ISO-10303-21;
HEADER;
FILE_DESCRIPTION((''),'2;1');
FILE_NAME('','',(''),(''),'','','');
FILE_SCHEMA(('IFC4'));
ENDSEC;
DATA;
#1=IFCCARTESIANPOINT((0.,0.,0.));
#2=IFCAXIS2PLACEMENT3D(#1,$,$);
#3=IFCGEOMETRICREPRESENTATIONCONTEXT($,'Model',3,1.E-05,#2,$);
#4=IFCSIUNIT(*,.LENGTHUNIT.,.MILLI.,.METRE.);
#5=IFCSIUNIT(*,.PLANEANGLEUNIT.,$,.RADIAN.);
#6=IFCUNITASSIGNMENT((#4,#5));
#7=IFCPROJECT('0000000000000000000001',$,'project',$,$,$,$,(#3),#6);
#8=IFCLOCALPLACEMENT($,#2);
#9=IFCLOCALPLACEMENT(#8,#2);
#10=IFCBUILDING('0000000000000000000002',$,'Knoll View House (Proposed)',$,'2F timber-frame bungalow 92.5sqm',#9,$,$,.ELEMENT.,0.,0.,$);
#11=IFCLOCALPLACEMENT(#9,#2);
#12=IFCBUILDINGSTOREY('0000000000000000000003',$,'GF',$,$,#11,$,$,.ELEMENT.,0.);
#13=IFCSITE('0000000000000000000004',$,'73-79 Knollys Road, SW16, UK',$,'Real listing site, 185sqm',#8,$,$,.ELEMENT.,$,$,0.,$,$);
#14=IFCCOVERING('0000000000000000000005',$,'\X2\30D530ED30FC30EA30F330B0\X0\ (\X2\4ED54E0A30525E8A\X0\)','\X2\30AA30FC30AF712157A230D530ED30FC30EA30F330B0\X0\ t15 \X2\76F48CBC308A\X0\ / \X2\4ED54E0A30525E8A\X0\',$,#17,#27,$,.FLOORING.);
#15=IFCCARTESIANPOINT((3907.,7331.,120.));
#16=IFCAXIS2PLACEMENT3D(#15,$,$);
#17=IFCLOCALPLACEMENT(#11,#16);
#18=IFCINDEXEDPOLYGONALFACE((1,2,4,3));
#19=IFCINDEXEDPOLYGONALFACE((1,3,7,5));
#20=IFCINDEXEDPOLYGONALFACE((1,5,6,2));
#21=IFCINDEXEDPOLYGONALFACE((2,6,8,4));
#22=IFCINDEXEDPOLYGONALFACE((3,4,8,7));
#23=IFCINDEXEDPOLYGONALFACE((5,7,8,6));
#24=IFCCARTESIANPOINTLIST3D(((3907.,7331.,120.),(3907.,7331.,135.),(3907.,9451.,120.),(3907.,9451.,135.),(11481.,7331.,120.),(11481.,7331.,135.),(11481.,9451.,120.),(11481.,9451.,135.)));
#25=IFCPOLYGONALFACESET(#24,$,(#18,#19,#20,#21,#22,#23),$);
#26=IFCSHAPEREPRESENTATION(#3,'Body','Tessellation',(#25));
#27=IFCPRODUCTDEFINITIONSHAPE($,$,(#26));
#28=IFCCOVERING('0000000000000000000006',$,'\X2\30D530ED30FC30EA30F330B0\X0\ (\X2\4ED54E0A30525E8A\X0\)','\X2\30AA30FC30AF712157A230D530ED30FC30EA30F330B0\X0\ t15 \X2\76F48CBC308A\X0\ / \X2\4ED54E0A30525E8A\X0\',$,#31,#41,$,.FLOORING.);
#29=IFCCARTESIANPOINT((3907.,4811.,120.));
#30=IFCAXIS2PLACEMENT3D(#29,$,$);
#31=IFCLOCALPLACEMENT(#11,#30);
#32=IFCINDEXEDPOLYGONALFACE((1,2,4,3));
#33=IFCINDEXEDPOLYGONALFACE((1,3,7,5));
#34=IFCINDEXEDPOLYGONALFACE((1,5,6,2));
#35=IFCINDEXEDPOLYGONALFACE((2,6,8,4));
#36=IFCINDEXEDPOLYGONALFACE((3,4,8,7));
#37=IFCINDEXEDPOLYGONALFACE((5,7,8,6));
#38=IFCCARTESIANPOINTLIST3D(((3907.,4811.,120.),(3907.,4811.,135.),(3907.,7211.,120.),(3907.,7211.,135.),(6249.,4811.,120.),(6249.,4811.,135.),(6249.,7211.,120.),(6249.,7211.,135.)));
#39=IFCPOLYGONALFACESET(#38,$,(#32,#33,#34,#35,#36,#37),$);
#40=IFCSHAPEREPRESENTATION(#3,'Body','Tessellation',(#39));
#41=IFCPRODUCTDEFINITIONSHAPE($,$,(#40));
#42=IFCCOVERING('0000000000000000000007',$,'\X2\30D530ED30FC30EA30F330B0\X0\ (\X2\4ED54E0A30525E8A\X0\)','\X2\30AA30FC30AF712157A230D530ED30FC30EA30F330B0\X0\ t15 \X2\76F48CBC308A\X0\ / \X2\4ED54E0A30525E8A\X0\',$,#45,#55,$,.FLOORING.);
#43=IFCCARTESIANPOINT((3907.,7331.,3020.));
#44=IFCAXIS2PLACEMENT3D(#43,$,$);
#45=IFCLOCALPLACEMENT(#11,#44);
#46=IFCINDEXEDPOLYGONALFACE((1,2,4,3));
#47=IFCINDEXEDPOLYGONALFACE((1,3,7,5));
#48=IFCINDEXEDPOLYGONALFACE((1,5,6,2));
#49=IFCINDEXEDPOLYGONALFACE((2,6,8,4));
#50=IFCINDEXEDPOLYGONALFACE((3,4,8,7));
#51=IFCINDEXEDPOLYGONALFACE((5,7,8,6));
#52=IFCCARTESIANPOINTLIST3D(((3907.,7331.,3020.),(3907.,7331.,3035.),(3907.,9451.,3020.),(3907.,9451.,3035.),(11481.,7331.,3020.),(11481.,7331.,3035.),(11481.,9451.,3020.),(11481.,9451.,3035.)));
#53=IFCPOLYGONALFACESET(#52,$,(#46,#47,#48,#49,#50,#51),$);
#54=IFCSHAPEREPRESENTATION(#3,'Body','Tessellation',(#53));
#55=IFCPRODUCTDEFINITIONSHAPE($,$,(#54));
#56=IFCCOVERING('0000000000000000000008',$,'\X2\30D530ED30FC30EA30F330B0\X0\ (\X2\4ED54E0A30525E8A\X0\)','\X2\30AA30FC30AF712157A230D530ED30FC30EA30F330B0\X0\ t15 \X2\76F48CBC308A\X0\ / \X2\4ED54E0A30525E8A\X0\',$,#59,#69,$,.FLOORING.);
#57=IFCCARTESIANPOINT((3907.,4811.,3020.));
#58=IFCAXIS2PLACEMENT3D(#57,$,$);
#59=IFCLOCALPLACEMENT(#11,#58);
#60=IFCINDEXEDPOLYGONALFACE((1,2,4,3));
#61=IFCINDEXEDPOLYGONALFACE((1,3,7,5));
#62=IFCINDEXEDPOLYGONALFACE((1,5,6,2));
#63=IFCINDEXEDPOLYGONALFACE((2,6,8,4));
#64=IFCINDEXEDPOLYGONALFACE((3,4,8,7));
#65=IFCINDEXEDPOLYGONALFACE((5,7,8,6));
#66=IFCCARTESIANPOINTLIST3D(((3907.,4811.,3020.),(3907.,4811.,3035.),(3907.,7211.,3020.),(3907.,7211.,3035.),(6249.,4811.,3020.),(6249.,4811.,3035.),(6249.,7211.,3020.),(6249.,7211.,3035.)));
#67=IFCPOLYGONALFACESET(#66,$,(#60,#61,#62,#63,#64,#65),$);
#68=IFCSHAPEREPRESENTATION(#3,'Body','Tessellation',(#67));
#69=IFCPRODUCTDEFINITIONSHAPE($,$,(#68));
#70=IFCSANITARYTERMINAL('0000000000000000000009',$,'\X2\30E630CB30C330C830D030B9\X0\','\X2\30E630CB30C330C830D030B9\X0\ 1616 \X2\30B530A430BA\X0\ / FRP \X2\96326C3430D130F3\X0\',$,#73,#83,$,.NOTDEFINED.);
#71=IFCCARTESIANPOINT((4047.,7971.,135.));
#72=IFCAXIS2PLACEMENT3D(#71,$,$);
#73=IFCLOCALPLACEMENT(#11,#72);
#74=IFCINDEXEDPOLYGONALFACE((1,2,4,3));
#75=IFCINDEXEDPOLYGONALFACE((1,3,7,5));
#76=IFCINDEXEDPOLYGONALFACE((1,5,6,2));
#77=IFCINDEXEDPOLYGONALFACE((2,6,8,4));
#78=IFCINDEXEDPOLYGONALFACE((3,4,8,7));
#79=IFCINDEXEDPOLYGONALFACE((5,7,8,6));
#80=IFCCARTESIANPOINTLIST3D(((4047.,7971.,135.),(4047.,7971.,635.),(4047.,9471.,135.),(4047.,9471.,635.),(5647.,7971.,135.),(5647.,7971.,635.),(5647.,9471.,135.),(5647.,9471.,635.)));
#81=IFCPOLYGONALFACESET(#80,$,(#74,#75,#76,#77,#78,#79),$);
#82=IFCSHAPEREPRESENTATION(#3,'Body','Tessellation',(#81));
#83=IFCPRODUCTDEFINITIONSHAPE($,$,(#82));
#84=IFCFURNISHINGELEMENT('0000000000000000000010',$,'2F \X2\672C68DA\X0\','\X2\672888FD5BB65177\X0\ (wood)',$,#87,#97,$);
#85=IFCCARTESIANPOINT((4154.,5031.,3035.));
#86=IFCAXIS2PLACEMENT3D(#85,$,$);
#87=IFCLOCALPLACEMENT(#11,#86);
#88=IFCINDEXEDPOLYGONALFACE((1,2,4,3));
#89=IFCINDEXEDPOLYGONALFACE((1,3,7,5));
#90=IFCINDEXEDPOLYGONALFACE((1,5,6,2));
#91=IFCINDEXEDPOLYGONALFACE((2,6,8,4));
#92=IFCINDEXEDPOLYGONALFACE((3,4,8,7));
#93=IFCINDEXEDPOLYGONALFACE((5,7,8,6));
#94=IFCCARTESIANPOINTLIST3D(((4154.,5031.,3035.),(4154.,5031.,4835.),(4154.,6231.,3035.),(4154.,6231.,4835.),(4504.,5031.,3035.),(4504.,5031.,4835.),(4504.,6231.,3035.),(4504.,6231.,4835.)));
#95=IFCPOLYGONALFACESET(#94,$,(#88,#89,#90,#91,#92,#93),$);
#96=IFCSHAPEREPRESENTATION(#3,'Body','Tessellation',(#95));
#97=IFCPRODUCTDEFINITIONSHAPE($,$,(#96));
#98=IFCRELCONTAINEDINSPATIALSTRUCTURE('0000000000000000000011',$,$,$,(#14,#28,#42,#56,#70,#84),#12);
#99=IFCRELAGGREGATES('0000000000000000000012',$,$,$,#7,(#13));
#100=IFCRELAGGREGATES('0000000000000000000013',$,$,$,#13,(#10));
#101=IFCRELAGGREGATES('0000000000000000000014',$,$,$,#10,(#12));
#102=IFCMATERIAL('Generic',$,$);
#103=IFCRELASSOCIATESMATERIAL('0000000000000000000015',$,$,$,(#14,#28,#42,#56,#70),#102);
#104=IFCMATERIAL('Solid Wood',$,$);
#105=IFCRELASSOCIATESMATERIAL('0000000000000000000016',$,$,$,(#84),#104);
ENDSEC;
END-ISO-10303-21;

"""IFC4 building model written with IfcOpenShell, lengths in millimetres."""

from ifc_helpers import new_model, si_unit, frame, frame_2d, origin, place, context, project, spatial, rectangle, extrude, material, element, save


model = new_model("IFC4")

# Units and contexts
model_context = context("Model", 3, precision=1e-05, world=origin())
ifc_project = project(units=[si_unit("LENGTHUNIT", "METRE", prefix="MILLI"), si_unit("PLANEANGLEUNIT", "RADIAN")], contexts=[model_context])

# Site, building, storey
site_placement = place(None, origin())
site = spatial("IfcSite", under=ifc_project, at=site_placement, Name="73-79 Knollys Road, SW16, UK", ObjectType="Real listing site, 185sqm", CompositionType="ELEMENT", RefElevation=0.0)
building_placement = place(site_placement, origin())
building = spatial("IfcBuilding", under=site, at=building_placement, Name="Knoll View House (Proposed)", ObjectType="2F timber-frame bungalow 92.5sqm", CompositionType="ELEMENT", ElevationOfRefHeight=0.0, ElevationOfTerrain=0.0)
storey_placement = place(building_placement, origin())
storey = spatial("IfcBuildingStorey", under=building, at=storey_placement, Name="GF", CompositionType="ELEMENT", Elevation=0.0)

# Shared definitions
ifc_material_1 = material(Name="Solid Wood")

# Coverings
ifc_material_2 = material(Name="Generic")
covering_1_placement = place(storey_placement, frame((3907.0, 7331.0, 120.0)))
element("IfcCovering", 1, at=covering_1_placement, inside=storey, material=ifc_material_2, Name="フローリング (仕上げ床)", Description="オーク無垢フローリング t15 直貼り / 仕上げ床", PredefinedType="FLOORING", context=model_context, shape_type="SweptSolid", body=[
    extrude(rectangle(XDim=7574.0, YDim=2120.0, at=frame_2d((3787.0, 1060.0))), frame((3907.0, 7331.0, 120.0)), (0.0, 0.0, 1.0), 15.0),
])
covering_2_placement = place(storey_placement, frame((3907.0, 4811.0, 120.0)))
element("IfcCovering", 2, at=covering_2_placement, inside=storey, material=ifc_material_2, Name="フローリング (仕上げ床)", Description="オーク無垢フローリング t15 直貼り / 仕上げ床", PredefinedType="FLOORING", context=model_context, shape_type="SweptSolid", body=[
    extrude(rectangle(XDim=2342.0, YDim=2400.0, at=frame_2d((1171.0, 1200.0))), frame((3907.0, 4811.0, 120.0)), (0.0, 0.0, 1.0), 15.0),
])
covering_3_placement = place(storey_placement, frame((3907.0, 7331.0, 3020.0)))
element("IfcCovering", 3, at=covering_3_placement, inside=storey, material=ifc_material_2, Name="フローリング (仕上げ床)", Description="オーク無垢フローリング t15 直貼り / 仕上げ床", PredefinedType="FLOORING", context=model_context, shape_type="SweptSolid", body=[
    extrude(rectangle(XDim=7574.0, YDim=2120.0, at=frame_2d((3787.0, 1060.0))), frame((3907.0, 7331.0, 3020.0)), (0.0, 0.0, 1.0), 15.0),
])
covering_4_placement = place(storey_placement, frame((3907.0, 4811.0, 3020.0)))
element("IfcCovering", 4, at=covering_4_placement, inside=storey, material=ifc_material_2, Name="フローリング (仕上げ床)", Description="オーク無垢フローリング t15 直貼り / 仕上げ床", PredefinedType="FLOORING", context=model_context, shape_type="SweptSolid", body=[
    extrude(rectangle(XDim=2342.0, YDim=2400.0, at=frame_2d((1171.0, 1200.0))), frame((3907.0, 4811.0, 3020.0)), (0.0, 0.0, 1.0), 15.0),
])

# Sanitary terminal
sanitary_terminal_placement = place(storey_placement, frame((4047.0, 7971.0, 135.0)))
element("IfcSanitaryTerminal", 5, at=sanitary_terminal_placement, inside=storey, material=ifc_material_2, Name="ユニットバス", Description="ユニットバス 1616 サイズ / FRP 防水パン", PredefinedType="NOTDEFINED", context=model_context, shape_type="SweptSolid", body=[
    extrude(rectangle(XDim=1600.0, YDim=1500.0, at=frame_2d((800.0, 750.0))), frame((4047.0, 7971.0, 135.0)), (0.0, 0.0, 1.0), 500.0),
])

# Furnishing element
furnishing_placement = place(storey_placement, frame((4154.0, 5031.0, 3035.0)))
element("IfcFurnishingElement", 6, at=furnishing_placement, inside=storey, material=ifc_material_1, Name="2F 本棚", Description="木製家具 (wood)", context=model_context, shape_type="SweptSolid", body=[
    extrude(rectangle(XDim=350.0, YDim=1200.0, at=frame_2d((175.0, 600.0))), frame((4154.0, 5031.0, 3035.0)), (0.0, 0.0, 1.0), 1800.0),
])

save(model, "model.ifc")
